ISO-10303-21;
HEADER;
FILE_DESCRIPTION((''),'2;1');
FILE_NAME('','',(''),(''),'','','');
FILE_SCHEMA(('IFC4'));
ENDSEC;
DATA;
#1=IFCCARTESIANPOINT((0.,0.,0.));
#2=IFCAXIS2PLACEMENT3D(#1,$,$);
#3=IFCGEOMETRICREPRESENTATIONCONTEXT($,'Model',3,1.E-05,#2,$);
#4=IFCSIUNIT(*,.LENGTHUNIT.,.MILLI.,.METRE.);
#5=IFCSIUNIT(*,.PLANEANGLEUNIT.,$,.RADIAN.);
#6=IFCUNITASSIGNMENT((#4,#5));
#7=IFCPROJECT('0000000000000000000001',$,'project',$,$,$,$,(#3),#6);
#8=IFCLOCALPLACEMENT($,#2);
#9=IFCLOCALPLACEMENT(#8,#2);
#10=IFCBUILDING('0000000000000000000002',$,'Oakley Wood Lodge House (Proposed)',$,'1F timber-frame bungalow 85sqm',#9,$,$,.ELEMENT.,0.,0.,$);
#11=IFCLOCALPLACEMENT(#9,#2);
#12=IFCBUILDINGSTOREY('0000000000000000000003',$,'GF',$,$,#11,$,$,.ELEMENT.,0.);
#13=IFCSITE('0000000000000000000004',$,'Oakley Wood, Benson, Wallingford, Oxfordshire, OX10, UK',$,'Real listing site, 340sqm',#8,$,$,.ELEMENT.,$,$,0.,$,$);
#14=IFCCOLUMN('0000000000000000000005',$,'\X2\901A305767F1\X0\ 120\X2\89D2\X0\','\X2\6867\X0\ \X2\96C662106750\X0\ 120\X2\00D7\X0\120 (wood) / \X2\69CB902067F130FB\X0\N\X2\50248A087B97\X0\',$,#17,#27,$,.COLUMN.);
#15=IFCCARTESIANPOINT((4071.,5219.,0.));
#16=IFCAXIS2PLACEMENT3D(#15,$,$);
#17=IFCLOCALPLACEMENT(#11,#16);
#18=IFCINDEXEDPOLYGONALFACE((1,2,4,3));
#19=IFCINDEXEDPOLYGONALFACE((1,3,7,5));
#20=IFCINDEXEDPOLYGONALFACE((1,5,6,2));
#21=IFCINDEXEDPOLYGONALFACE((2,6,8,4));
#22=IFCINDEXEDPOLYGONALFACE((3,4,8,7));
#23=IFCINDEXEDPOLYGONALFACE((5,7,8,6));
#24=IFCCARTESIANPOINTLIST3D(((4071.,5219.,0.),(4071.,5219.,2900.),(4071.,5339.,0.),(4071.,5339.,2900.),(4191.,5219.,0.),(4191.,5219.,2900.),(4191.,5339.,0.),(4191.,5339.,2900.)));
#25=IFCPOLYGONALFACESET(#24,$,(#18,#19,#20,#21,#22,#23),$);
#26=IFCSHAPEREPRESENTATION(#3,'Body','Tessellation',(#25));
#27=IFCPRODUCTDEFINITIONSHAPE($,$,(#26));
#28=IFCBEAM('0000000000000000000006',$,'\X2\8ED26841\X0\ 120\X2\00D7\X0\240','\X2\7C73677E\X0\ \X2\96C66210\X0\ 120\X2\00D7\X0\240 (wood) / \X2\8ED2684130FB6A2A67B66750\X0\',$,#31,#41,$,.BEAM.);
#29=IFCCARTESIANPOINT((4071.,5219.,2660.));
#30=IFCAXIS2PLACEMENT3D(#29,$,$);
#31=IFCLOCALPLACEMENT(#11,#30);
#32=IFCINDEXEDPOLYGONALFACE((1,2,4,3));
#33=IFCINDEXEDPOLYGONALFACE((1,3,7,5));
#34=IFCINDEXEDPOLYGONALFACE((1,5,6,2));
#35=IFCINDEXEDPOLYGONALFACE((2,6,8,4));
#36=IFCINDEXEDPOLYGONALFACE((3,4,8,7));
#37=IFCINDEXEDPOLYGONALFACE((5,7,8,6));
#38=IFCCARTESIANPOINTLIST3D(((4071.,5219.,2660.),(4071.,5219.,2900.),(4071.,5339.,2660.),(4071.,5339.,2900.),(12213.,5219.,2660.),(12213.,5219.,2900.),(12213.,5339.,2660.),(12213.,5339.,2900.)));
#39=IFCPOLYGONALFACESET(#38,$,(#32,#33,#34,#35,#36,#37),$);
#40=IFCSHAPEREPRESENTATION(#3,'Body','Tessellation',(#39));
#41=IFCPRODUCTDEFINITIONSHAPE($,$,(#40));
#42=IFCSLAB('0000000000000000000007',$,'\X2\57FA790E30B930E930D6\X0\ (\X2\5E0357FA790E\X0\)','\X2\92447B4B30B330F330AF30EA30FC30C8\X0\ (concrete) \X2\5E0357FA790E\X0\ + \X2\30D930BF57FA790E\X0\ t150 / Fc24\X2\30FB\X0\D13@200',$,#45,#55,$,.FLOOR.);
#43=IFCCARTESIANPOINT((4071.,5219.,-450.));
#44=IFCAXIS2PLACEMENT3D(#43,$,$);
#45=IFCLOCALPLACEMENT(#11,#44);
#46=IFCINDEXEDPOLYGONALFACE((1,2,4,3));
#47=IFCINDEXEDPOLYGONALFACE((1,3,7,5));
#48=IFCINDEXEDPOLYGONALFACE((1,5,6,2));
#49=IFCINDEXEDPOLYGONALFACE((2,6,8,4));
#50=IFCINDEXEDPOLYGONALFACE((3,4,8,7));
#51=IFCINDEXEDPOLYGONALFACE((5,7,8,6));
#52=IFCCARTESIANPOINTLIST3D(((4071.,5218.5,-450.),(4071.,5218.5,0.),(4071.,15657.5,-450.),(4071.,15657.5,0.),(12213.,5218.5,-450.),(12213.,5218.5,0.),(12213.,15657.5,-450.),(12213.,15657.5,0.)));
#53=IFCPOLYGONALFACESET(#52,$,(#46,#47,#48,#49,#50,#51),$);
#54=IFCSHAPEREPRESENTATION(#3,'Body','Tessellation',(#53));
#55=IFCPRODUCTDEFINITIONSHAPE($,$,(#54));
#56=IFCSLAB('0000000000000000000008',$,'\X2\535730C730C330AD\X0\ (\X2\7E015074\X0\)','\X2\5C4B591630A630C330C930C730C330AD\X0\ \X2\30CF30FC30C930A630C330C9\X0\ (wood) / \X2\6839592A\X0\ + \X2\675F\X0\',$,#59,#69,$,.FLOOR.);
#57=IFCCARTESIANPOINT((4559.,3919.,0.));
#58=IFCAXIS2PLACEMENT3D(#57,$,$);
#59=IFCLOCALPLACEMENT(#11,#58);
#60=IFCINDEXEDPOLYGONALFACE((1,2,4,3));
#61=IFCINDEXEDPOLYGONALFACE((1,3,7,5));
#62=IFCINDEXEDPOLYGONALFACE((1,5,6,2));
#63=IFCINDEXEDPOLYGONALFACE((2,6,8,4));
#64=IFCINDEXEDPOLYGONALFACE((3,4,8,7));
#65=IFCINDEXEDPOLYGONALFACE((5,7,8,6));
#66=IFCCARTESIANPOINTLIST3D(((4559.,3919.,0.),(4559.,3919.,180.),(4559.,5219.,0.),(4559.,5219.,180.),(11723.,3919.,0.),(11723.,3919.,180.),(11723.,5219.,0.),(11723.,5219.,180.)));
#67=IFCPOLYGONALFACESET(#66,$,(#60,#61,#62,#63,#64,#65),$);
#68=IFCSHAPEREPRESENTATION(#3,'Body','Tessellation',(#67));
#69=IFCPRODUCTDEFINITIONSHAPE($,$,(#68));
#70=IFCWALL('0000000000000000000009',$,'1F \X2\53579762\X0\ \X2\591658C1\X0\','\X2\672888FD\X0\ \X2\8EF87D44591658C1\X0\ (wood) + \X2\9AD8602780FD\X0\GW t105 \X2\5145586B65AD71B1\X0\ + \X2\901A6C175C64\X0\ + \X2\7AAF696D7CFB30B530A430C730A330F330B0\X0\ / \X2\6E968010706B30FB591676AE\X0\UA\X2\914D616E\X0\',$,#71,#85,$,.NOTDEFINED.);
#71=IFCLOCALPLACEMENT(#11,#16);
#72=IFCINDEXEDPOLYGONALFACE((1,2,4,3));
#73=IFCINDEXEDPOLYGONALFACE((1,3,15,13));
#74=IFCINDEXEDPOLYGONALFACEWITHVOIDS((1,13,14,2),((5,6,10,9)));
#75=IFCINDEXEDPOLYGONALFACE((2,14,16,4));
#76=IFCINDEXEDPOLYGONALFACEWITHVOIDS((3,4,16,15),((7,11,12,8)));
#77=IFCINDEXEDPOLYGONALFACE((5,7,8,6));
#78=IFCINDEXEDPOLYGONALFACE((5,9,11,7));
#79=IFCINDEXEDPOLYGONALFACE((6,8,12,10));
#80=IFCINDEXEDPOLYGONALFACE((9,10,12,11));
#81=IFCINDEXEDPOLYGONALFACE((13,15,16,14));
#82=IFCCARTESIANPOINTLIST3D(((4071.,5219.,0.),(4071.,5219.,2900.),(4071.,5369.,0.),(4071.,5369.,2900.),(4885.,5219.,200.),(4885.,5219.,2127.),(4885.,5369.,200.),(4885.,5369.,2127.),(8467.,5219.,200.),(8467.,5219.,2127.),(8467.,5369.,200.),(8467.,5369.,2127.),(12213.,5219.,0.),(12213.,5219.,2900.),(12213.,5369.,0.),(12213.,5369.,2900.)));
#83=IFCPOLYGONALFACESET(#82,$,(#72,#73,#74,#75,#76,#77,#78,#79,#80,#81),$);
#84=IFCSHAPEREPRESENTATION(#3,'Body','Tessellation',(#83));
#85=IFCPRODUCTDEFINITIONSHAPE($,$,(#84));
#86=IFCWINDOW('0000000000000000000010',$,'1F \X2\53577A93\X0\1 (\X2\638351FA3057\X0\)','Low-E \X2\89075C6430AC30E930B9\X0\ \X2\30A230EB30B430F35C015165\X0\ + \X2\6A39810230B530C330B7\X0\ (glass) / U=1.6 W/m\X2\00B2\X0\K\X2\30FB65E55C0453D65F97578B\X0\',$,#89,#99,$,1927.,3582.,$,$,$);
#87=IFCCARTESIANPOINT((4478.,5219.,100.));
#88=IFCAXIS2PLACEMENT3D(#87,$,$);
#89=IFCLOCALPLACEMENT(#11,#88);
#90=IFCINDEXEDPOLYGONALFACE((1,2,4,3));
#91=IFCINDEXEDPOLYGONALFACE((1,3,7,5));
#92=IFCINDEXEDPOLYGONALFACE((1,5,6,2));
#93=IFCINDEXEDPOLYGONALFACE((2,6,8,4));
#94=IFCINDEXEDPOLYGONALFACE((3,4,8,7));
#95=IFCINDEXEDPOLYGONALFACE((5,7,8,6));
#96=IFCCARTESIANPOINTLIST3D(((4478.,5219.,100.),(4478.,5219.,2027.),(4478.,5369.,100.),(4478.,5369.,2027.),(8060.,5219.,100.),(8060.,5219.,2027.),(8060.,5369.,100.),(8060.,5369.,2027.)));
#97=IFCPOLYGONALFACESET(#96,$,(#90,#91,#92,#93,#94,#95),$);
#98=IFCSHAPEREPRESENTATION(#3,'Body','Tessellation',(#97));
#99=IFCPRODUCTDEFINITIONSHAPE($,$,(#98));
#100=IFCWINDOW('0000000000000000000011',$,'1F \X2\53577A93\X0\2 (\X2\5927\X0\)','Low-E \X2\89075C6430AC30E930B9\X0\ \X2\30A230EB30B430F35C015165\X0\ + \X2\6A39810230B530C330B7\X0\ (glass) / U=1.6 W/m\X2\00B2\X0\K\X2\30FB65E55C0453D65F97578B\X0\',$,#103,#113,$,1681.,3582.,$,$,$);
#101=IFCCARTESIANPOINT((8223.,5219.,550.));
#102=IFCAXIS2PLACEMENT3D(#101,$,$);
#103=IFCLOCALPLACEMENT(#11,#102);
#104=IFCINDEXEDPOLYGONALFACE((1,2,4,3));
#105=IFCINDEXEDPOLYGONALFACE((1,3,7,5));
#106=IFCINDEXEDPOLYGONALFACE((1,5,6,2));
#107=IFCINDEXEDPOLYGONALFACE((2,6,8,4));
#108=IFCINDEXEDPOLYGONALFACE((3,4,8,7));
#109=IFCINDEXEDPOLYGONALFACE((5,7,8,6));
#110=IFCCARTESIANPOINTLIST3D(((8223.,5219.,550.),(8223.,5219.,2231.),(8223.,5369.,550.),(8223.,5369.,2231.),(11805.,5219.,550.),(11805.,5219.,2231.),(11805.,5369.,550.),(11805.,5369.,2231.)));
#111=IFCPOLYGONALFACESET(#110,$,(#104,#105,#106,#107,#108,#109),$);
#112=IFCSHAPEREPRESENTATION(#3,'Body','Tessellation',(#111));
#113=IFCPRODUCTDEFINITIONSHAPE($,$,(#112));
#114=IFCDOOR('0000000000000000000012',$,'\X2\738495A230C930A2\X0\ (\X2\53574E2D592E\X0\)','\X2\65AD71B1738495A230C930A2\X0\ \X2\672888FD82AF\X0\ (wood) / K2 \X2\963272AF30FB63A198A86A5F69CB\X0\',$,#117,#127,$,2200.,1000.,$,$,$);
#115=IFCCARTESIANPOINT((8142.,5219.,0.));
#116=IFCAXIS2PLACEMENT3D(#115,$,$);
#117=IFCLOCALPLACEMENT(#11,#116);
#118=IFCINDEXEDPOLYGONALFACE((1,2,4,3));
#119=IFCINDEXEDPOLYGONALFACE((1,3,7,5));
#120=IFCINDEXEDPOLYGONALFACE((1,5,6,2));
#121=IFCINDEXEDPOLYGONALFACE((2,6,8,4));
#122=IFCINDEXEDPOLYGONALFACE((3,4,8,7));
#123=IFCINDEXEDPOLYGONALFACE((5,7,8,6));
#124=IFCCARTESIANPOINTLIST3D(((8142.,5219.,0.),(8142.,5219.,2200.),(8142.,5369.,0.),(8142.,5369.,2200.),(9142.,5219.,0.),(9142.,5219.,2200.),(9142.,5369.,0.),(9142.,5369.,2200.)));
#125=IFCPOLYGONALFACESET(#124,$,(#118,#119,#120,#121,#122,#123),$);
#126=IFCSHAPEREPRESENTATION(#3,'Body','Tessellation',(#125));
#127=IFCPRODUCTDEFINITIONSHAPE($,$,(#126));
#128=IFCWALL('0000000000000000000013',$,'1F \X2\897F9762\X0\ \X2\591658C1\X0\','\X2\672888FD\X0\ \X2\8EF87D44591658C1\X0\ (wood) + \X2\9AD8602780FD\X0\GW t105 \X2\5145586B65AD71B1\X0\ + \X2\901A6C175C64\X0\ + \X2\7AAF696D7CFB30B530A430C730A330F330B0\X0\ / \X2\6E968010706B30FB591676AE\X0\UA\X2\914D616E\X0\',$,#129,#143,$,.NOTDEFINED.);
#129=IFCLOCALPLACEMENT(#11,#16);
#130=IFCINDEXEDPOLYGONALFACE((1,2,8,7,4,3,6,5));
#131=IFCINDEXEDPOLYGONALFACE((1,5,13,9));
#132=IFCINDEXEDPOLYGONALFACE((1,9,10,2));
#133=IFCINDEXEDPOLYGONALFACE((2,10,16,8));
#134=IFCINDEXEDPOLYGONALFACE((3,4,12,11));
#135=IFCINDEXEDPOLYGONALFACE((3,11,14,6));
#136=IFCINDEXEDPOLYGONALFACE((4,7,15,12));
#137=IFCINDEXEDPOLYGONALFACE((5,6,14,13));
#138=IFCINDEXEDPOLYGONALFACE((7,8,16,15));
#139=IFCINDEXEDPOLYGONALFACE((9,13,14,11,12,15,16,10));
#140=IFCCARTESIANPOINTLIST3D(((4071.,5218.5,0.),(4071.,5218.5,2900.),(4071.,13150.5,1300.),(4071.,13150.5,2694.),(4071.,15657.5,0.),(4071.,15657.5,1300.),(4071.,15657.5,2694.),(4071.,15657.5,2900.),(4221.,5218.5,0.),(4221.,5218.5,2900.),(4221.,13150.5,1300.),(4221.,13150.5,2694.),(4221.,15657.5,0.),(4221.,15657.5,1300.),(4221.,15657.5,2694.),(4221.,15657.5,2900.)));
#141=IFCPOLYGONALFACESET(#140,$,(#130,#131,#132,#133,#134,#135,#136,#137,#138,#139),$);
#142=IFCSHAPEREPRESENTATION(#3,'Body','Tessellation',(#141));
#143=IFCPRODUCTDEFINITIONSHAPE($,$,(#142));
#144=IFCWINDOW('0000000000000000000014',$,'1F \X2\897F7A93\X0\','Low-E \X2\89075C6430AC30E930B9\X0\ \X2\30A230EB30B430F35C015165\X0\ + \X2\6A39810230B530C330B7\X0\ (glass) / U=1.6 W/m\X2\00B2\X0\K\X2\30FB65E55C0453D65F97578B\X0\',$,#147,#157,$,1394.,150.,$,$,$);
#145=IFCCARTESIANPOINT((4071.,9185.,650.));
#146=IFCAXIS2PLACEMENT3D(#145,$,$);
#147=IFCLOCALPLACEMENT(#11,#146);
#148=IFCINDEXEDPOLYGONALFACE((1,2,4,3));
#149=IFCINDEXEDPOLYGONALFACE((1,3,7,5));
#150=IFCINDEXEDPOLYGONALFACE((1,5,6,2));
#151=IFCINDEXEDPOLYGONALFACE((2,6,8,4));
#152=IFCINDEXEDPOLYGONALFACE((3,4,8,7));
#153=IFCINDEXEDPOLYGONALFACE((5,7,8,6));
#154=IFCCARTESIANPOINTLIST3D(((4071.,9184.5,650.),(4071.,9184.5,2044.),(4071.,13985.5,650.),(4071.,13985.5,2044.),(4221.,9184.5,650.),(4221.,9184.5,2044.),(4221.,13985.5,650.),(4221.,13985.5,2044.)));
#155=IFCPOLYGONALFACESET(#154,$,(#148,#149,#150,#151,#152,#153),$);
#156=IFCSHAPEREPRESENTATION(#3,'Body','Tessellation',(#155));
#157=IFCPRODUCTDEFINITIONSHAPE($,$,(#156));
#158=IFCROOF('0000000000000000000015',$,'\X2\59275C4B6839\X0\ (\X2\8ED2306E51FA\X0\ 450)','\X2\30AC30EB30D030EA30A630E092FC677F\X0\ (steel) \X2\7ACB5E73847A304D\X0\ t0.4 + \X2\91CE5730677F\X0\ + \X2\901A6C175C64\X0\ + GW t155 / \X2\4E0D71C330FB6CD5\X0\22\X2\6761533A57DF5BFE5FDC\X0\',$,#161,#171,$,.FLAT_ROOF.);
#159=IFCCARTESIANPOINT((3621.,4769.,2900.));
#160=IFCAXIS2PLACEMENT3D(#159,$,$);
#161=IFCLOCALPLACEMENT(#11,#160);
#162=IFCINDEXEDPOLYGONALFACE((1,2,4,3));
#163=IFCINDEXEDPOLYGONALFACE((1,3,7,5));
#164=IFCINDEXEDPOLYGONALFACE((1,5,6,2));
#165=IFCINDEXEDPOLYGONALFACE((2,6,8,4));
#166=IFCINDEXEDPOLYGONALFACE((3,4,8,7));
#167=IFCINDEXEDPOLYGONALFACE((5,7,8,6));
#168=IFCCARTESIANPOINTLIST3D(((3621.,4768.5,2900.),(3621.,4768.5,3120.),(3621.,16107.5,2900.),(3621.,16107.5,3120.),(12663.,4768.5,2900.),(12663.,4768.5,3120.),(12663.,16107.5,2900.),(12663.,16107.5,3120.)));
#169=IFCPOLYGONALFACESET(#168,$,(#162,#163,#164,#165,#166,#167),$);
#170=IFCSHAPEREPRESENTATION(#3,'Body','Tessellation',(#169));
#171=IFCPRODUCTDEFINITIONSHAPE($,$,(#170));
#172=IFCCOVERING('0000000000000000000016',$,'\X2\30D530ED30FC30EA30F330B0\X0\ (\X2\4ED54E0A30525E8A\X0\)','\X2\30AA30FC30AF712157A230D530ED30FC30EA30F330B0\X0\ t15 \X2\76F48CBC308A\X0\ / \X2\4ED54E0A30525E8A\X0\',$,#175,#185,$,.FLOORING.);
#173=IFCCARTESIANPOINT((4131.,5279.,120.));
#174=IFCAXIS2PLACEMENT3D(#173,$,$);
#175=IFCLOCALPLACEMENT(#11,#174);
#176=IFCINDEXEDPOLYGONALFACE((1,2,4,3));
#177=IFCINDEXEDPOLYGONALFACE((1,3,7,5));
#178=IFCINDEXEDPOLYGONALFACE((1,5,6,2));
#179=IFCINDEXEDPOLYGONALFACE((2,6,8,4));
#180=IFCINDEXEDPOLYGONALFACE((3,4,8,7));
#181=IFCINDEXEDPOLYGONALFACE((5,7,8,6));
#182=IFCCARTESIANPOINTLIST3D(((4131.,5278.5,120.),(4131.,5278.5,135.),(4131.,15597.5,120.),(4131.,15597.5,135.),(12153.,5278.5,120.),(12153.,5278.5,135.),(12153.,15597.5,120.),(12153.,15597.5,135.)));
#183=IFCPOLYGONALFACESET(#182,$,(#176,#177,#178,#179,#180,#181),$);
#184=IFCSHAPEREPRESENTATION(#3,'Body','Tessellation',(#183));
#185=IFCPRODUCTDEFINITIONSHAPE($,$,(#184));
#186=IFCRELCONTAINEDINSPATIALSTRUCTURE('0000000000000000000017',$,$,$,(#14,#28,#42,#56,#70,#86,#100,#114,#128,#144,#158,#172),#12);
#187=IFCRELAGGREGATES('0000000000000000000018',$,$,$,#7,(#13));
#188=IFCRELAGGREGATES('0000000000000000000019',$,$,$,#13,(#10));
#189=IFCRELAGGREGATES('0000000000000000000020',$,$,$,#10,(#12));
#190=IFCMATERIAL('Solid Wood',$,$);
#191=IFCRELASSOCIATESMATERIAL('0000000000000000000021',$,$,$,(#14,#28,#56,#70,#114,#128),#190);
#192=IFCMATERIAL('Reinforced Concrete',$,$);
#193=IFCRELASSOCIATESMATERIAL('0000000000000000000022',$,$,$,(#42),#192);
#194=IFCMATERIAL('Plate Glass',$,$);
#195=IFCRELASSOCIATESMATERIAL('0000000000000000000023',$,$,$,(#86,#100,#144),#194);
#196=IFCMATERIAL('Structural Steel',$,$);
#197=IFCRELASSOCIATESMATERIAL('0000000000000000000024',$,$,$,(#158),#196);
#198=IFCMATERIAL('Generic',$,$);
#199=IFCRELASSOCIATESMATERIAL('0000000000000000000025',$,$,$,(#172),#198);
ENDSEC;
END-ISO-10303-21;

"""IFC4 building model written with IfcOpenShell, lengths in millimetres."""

from ifc_helpers import new_model, si_unit, frame, frame_2d, origin, place, context, project, spatial, rectangle, extrude, material, element, fill, save


model = new_model("IFC4")

# Units and contexts
model_context = context("Model", 3, precision=1e-05, world=origin())
ifc_project = project(units=[si_unit("LENGTHUNIT", "METRE", prefix="MILLI"), si_unit("PLANEANGLEUNIT", "RADIAN")], contexts=[model_context])

# Site, building, storey
site_placement = place(None, origin())
site = spatial("IfcSite", under=ifc_project, at=site_placement, Name="Oakley Wood, Benson, Wallingford, Oxfordshire, OX10, UK", ObjectType="Real listing site, 340sqm", CompositionType="ELEMENT", RefElevation=0.0)
building_placement = place(site_placement, origin())
building = spatial("IfcBuilding", under=site, at=building_placement, Name="Oakley Wood Lodge House (Proposed)", ObjectType="1F timber-frame bungalow 85sqm", CompositionType="ELEMENT", ElevationOfRefHeight=0.0, ElevationOfTerrain=0.0)
storey_placement = place(building_placement, origin())
storey = spatial("IfcBuildingStorey", under=building, at=storey_placement, Name="GF", CompositionType="ELEMENT", Elevation=0.0)

# Column
ifc_material_1 = material(Name="Solid Wood")
column_1_placement = place(storey_placement, frame((4071.0, 5219.0, 0.0)))
element("IfcColumn", 1, at=column_1_placement, inside=storey, material=ifc_material_1, Name="通し柱 120角", Description="桧 集成材 120×120 (wood) / 構造柱・N値計算", PredefinedType="COLUMN", context=model_context, shape_type="SweptSolid", body=[
    extrude(rectangle(XDim=120.0, YDim=120.0, at=frame_2d((60.0, 60.0))), frame((4071.0, 5219.0, 0.0)), (0.0, 0.0, 1.0), 2900.0),
])

# Beam
beam_1_placement = place(storey_placement, frame((4071.0, 5219.0, 2660.0)))
element("IfcBeam", 2, at=beam_1_placement, inside=storey, material=ifc_material_1, Name="軒桁 120×240", Description="米松 集成 120×240 (wood) / 軒桁・横架材", PredefinedType="BEAM", context=model_context, shape_type="SweptSolid", body=[
    extrude(rectangle(XDim=8142.0, YDim=120.0, at=frame_2d((4071.0, 60.0))), frame((4071.0, 5219.0, 2660.0)), (0.0, 0.0, 1.0), 240.0),
])

# Slabs
ifc_material_2 = material(Name="Reinforced Concrete")
slab_1_placement = place(storey_placement, frame((4071.0, 5219.0, -450.0)))
element("IfcSlab", 3, at=slab_1_placement, inside=storey, material=ifc_material_2, Name="基礎スラブ (布基礎)", Description="鉄筋コンクリート (concrete) 布基礎 + ベタ基礎 t150 / Fc24・D13@200", PredefinedType="FLOOR", context=model_context, shape_type="SweptSolid", body=[
    extrude(rectangle(XDim=8142.0, YDim=10439.0, at=frame_2d((4071.0, 5219.0))), frame((4071.0, 5219.0, -450.0)), (0.0, 0.0, 1.0), 450.0),
])
slab_2_placement = place(storey_placement, frame((4559.0, 3919.0, 0.0)))
element("IfcSlab", 4, at=slab_2_placement, inside=storey, material=ifc_material_1, Name="南デッキ (縁側)", Description="屋外ウッドデッキ ハードウッド (wood) / 根太 + 束", PredefinedType="FLOOR", context=model_context, shape_type="SweptSolid", body=[
    extrude(rectangle(XDim=7164.0, YDim=1300.0, at=frame_2d((3582.0, 650.0))), frame((4559.0, 3919.0, 0.0)), (0.0, 0.0, 1.0), 180.0),
])

# Wall, openings, windows, door
wall_1_placement = place(storey_placement, frame((4071.0, 5219.0, 0.0)))
wall_1 = element("IfcWall", 5, at=wall_1_placement, inside=storey, material=ifc_material_1, Name="1F 南面 外壁", Description="木製 軸組外壁 (wood) + 高性能GW t105 充填断熱 + 通気層 + 窯業系サイディング / 準耐火・外皮UA配慮", PredefinedType="NOTDEFINED", context=model_context, shape_type="SweptSolid", body=[
    extrude(rectangle(XDim=8142.0, YDim=150.0, at=frame_2d((4071.0, 75.0))), frame((4071.0, 5219.0, 0.0)), (0.0, 0.0, 1.0), 2900.0),
])
opening_1_placement = place(storey_placement, frame((4478.0, 5219.0, 100.0)))
opening_1 = element("IfcOpeningElement", 6, at=opening_1_placement, cuts=wall_1, PredefinedType="NOTDEFINED", context=model_context, shape_type="SweptSolid", body=[
    extrude(rectangle(XDim=3582.0, YDim=150.0, at=frame_2d((1791.0, 75.0))), frame((4478.0, 5219.0, 100.0)), (0.0, 0.0, 1.0), 1927.0),
])
opening_2_placement = place(storey_placement, frame((8223.0, 5219.0, 550.0)))
opening_2 = element("IfcOpeningElement", 7, at=opening_2_placement, cuts=wall_1, PredefinedType="NOTDEFINED", context=model_context, shape_type="SweptSolid", body=[
    extrude(rectangle(XDim=3582.0, YDim=150.0, at=frame_2d((1791.0, 75.0))), frame((8223.0, 5219.0, 550.0)), (0.0, 0.0, 1.0), 1681.0),
])
opening_3_placement = place(storey_placement, frame((8142.0, 5219.0, 0.0)))
opening_3 = element("IfcOpeningElement", 8, at=opening_3_placement, cuts=wall_1, PredefinedType="NOTDEFINED", context=model_context, shape_type="SweptSolid", body=[
    extrude(rectangle(XDim=1000.0, YDim=150.0, at=frame_2d((500.0, 75.0))), frame((8142.0, 5219.0, 0.0)), (0.0, 0.0, 1.0), 2200.0),
])
ifc_material_3 = material(Name="Plate Glass")
window_1_placement = place(storey_placement, frame((4478.0, 5219.0, 100.0)))
window_1 = element("IfcWindow", 9, at=window_1_placement, inside=storey, material=ifc_material_3, Name="1F 南窓1 (掃出し)", Description="Low-E 複層ガラス アルゴン封入 + 樹脂サッシ (glass) / U=1.6 W/m²K・日射取得型", OverallHeight=1927.0, OverallWidth=3582.0, context=model_context, shape_type="SweptSolid", body=[
    extrude(rectangle(XDim=3582.0, YDim=150.0, at=frame_2d((1791.0, 75.0))), frame((4478.0, 5219.0, 100.0)), (0.0, 0.0, 1.0), 1927.0),
])
fill(opening_1, window_1)
window_2_placement = place(storey_placement, frame((8223.0, 5219.0, 550.0)))
window_2 = element("IfcWindow", 10, at=window_2_placement, inside=storey, material=ifc_material_3, Name="1F 南窓2 (大)", Description="Low-E 複層ガラス アルゴン封入 + 樹脂サッシ (glass) / U=1.6 W/m²K・日射取得型", OverallHeight=1681.0, OverallWidth=3582.0, context=model_context, shape_type="SweptSolid", body=[
    extrude(rectangle(XDim=3582.0, YDim=150.0, at=frame_2d((1791.0, 75.0))), frame((8223.0, 5219.0, 550.0)), (0.0, 0.0, 1.0), 1681.0),
])
fill(opening_2, window_2)
door_placement = place(storey_placement, frame((8142.0, 5219.0, 0.0)))
door = element("IfcDoor", 11, at=door_placement, inside=storey, material=ifc_material_1, Name="玄関ドア (南中央)", Description="断熱玄関ドア 木製芯 (wood) / K2 防犯・採風機構", OverallHeight=2200.0, OverallWidth=1000.0, context=model_context, shape_type="SweptSolid", body=[
    extrude(rectangle(XDim=1000.0, YDim=150.0, at=frame_2d((500.0, 75.0))), frame((8142.0, 5219.0, 0.0)), (0.0, 0.0, 1.0), 2200.0),
])
fill(opening_3, door)

# Wall, opening, window
wall_2_placement = place(storey_placement, frame((4071.0, 5219.0, 0.0)))
wall_2 = element("IfcWall", 12, at=wall_2_placement, inside=storey, material=ifc_material_1, Name="1F 西面 外壁", Description="木製 軸組外壁 (wood) + 高性能GW t105 充填断熱 + 通気層 + 窯業系サイディング / 準耐火・外皮UA配慮", PredefinedType="NOTDEFINED", context=model_context, shape_type="SweptSolid", body=[
    extrude(rectangle(XDim=150.0, YDim=10439.0, at=frame_2d((75.0, 5219.0))), frame((4071.0, 5219.0, 0.0)), (0.0, 0.0, 1.0), 2900.0),
])
opening_4_placement = place(storey_placement, frame((4071.0, 9185.0, 650.0)))
opening_4 = element("IfcOpeningElement", 13, at=opening_4_placement, cuts=wall_2, PredefinedType="NOTDEFINED", context=model_context, shape_type="SweptSolid", body=[
    extrude(rectangle(XDim=150.0, YDim=4801.0, at=frame_2d((75.0, 2400.0))), frame((4071.0, 9185.0, 650.0)), (0.0, 0.0, 1.0), 1394.0),
])
window_3_placement = place(storey_placement, frame((4071.0, 9185.0, 650.0)))
window_3 = element("IfcWindow", 14, at=window_3_placement, inside=storey, material=ifc_material_3, Name="1F 西窓", Description="Low-E 複層ガラス アルゴン封入 + 樹脂サッシ (glass) / U=1.6 W/m²K・日射取得型", OverallHeight=1394.0, OverallWidth=150.0, context=model_context, shape_type="SweptSolid", body=[
    extrude(rectangle(XDim=150.0, YDim=4801.0, at=frame_2d((75.0, 2400.0))), frame((4071.0, 9185.0, 650.0)), (0.0, 0.0, 1.0), 1394.0),
])
fill(opening_4, window_3)

# Roof
ifc_material_4 = material(Name="Structural Steel")
roof_placement = place(storey_placement, frame((3621.0, 4769.0, 2900.0)))
element("IfcRoof", 15, at=roof_placement, inside=storey, material=ifc_material_4, Name="大屋根 (軒の出 450)", Description="ガルバリウム鋼板 (steel) 立平葺き t0.4 + 野地板 + 通気層 + GW t155 / 不燃・法22条区域対応", PredefinedType="FLAT_ROOF", context=model_context, shape_type="SweptSolid", body=[
    extrude(rectangle(XDim=9042.0, YDim=11339.0, at=frame_2d((4521.0, 5669.0))), frame((3621.0, 4769.0, 2900.0)), (0.0, 0.0, 1.0), 220.0),
])

# Covering
ifc_material_5 = material(Name="Generic")
covering_1_placement = place(storey_placement, frame((4131.0, 5279.0, 120.0)))
element("IfcCovering", 16, at=covering_1_placement, inside=storey, material=ifc_material_5, Name="フローリング (仕上げ床)", Description="オーク無垢フローリング t15 直貼り / 仕上げ床", PredefinedType="FLOORING", context=model_context, shape_type="SweptSolid", body=[
    extrude(rectangle(XDim=8022.0, YDim=10319.0, at=frame_2d((4011.0, 5159.0))), frame((4131.0, 5279.0, 120.0)), (0.0, 0.0, 1.0), 15.0),
])

save(model, "model.ifc")
